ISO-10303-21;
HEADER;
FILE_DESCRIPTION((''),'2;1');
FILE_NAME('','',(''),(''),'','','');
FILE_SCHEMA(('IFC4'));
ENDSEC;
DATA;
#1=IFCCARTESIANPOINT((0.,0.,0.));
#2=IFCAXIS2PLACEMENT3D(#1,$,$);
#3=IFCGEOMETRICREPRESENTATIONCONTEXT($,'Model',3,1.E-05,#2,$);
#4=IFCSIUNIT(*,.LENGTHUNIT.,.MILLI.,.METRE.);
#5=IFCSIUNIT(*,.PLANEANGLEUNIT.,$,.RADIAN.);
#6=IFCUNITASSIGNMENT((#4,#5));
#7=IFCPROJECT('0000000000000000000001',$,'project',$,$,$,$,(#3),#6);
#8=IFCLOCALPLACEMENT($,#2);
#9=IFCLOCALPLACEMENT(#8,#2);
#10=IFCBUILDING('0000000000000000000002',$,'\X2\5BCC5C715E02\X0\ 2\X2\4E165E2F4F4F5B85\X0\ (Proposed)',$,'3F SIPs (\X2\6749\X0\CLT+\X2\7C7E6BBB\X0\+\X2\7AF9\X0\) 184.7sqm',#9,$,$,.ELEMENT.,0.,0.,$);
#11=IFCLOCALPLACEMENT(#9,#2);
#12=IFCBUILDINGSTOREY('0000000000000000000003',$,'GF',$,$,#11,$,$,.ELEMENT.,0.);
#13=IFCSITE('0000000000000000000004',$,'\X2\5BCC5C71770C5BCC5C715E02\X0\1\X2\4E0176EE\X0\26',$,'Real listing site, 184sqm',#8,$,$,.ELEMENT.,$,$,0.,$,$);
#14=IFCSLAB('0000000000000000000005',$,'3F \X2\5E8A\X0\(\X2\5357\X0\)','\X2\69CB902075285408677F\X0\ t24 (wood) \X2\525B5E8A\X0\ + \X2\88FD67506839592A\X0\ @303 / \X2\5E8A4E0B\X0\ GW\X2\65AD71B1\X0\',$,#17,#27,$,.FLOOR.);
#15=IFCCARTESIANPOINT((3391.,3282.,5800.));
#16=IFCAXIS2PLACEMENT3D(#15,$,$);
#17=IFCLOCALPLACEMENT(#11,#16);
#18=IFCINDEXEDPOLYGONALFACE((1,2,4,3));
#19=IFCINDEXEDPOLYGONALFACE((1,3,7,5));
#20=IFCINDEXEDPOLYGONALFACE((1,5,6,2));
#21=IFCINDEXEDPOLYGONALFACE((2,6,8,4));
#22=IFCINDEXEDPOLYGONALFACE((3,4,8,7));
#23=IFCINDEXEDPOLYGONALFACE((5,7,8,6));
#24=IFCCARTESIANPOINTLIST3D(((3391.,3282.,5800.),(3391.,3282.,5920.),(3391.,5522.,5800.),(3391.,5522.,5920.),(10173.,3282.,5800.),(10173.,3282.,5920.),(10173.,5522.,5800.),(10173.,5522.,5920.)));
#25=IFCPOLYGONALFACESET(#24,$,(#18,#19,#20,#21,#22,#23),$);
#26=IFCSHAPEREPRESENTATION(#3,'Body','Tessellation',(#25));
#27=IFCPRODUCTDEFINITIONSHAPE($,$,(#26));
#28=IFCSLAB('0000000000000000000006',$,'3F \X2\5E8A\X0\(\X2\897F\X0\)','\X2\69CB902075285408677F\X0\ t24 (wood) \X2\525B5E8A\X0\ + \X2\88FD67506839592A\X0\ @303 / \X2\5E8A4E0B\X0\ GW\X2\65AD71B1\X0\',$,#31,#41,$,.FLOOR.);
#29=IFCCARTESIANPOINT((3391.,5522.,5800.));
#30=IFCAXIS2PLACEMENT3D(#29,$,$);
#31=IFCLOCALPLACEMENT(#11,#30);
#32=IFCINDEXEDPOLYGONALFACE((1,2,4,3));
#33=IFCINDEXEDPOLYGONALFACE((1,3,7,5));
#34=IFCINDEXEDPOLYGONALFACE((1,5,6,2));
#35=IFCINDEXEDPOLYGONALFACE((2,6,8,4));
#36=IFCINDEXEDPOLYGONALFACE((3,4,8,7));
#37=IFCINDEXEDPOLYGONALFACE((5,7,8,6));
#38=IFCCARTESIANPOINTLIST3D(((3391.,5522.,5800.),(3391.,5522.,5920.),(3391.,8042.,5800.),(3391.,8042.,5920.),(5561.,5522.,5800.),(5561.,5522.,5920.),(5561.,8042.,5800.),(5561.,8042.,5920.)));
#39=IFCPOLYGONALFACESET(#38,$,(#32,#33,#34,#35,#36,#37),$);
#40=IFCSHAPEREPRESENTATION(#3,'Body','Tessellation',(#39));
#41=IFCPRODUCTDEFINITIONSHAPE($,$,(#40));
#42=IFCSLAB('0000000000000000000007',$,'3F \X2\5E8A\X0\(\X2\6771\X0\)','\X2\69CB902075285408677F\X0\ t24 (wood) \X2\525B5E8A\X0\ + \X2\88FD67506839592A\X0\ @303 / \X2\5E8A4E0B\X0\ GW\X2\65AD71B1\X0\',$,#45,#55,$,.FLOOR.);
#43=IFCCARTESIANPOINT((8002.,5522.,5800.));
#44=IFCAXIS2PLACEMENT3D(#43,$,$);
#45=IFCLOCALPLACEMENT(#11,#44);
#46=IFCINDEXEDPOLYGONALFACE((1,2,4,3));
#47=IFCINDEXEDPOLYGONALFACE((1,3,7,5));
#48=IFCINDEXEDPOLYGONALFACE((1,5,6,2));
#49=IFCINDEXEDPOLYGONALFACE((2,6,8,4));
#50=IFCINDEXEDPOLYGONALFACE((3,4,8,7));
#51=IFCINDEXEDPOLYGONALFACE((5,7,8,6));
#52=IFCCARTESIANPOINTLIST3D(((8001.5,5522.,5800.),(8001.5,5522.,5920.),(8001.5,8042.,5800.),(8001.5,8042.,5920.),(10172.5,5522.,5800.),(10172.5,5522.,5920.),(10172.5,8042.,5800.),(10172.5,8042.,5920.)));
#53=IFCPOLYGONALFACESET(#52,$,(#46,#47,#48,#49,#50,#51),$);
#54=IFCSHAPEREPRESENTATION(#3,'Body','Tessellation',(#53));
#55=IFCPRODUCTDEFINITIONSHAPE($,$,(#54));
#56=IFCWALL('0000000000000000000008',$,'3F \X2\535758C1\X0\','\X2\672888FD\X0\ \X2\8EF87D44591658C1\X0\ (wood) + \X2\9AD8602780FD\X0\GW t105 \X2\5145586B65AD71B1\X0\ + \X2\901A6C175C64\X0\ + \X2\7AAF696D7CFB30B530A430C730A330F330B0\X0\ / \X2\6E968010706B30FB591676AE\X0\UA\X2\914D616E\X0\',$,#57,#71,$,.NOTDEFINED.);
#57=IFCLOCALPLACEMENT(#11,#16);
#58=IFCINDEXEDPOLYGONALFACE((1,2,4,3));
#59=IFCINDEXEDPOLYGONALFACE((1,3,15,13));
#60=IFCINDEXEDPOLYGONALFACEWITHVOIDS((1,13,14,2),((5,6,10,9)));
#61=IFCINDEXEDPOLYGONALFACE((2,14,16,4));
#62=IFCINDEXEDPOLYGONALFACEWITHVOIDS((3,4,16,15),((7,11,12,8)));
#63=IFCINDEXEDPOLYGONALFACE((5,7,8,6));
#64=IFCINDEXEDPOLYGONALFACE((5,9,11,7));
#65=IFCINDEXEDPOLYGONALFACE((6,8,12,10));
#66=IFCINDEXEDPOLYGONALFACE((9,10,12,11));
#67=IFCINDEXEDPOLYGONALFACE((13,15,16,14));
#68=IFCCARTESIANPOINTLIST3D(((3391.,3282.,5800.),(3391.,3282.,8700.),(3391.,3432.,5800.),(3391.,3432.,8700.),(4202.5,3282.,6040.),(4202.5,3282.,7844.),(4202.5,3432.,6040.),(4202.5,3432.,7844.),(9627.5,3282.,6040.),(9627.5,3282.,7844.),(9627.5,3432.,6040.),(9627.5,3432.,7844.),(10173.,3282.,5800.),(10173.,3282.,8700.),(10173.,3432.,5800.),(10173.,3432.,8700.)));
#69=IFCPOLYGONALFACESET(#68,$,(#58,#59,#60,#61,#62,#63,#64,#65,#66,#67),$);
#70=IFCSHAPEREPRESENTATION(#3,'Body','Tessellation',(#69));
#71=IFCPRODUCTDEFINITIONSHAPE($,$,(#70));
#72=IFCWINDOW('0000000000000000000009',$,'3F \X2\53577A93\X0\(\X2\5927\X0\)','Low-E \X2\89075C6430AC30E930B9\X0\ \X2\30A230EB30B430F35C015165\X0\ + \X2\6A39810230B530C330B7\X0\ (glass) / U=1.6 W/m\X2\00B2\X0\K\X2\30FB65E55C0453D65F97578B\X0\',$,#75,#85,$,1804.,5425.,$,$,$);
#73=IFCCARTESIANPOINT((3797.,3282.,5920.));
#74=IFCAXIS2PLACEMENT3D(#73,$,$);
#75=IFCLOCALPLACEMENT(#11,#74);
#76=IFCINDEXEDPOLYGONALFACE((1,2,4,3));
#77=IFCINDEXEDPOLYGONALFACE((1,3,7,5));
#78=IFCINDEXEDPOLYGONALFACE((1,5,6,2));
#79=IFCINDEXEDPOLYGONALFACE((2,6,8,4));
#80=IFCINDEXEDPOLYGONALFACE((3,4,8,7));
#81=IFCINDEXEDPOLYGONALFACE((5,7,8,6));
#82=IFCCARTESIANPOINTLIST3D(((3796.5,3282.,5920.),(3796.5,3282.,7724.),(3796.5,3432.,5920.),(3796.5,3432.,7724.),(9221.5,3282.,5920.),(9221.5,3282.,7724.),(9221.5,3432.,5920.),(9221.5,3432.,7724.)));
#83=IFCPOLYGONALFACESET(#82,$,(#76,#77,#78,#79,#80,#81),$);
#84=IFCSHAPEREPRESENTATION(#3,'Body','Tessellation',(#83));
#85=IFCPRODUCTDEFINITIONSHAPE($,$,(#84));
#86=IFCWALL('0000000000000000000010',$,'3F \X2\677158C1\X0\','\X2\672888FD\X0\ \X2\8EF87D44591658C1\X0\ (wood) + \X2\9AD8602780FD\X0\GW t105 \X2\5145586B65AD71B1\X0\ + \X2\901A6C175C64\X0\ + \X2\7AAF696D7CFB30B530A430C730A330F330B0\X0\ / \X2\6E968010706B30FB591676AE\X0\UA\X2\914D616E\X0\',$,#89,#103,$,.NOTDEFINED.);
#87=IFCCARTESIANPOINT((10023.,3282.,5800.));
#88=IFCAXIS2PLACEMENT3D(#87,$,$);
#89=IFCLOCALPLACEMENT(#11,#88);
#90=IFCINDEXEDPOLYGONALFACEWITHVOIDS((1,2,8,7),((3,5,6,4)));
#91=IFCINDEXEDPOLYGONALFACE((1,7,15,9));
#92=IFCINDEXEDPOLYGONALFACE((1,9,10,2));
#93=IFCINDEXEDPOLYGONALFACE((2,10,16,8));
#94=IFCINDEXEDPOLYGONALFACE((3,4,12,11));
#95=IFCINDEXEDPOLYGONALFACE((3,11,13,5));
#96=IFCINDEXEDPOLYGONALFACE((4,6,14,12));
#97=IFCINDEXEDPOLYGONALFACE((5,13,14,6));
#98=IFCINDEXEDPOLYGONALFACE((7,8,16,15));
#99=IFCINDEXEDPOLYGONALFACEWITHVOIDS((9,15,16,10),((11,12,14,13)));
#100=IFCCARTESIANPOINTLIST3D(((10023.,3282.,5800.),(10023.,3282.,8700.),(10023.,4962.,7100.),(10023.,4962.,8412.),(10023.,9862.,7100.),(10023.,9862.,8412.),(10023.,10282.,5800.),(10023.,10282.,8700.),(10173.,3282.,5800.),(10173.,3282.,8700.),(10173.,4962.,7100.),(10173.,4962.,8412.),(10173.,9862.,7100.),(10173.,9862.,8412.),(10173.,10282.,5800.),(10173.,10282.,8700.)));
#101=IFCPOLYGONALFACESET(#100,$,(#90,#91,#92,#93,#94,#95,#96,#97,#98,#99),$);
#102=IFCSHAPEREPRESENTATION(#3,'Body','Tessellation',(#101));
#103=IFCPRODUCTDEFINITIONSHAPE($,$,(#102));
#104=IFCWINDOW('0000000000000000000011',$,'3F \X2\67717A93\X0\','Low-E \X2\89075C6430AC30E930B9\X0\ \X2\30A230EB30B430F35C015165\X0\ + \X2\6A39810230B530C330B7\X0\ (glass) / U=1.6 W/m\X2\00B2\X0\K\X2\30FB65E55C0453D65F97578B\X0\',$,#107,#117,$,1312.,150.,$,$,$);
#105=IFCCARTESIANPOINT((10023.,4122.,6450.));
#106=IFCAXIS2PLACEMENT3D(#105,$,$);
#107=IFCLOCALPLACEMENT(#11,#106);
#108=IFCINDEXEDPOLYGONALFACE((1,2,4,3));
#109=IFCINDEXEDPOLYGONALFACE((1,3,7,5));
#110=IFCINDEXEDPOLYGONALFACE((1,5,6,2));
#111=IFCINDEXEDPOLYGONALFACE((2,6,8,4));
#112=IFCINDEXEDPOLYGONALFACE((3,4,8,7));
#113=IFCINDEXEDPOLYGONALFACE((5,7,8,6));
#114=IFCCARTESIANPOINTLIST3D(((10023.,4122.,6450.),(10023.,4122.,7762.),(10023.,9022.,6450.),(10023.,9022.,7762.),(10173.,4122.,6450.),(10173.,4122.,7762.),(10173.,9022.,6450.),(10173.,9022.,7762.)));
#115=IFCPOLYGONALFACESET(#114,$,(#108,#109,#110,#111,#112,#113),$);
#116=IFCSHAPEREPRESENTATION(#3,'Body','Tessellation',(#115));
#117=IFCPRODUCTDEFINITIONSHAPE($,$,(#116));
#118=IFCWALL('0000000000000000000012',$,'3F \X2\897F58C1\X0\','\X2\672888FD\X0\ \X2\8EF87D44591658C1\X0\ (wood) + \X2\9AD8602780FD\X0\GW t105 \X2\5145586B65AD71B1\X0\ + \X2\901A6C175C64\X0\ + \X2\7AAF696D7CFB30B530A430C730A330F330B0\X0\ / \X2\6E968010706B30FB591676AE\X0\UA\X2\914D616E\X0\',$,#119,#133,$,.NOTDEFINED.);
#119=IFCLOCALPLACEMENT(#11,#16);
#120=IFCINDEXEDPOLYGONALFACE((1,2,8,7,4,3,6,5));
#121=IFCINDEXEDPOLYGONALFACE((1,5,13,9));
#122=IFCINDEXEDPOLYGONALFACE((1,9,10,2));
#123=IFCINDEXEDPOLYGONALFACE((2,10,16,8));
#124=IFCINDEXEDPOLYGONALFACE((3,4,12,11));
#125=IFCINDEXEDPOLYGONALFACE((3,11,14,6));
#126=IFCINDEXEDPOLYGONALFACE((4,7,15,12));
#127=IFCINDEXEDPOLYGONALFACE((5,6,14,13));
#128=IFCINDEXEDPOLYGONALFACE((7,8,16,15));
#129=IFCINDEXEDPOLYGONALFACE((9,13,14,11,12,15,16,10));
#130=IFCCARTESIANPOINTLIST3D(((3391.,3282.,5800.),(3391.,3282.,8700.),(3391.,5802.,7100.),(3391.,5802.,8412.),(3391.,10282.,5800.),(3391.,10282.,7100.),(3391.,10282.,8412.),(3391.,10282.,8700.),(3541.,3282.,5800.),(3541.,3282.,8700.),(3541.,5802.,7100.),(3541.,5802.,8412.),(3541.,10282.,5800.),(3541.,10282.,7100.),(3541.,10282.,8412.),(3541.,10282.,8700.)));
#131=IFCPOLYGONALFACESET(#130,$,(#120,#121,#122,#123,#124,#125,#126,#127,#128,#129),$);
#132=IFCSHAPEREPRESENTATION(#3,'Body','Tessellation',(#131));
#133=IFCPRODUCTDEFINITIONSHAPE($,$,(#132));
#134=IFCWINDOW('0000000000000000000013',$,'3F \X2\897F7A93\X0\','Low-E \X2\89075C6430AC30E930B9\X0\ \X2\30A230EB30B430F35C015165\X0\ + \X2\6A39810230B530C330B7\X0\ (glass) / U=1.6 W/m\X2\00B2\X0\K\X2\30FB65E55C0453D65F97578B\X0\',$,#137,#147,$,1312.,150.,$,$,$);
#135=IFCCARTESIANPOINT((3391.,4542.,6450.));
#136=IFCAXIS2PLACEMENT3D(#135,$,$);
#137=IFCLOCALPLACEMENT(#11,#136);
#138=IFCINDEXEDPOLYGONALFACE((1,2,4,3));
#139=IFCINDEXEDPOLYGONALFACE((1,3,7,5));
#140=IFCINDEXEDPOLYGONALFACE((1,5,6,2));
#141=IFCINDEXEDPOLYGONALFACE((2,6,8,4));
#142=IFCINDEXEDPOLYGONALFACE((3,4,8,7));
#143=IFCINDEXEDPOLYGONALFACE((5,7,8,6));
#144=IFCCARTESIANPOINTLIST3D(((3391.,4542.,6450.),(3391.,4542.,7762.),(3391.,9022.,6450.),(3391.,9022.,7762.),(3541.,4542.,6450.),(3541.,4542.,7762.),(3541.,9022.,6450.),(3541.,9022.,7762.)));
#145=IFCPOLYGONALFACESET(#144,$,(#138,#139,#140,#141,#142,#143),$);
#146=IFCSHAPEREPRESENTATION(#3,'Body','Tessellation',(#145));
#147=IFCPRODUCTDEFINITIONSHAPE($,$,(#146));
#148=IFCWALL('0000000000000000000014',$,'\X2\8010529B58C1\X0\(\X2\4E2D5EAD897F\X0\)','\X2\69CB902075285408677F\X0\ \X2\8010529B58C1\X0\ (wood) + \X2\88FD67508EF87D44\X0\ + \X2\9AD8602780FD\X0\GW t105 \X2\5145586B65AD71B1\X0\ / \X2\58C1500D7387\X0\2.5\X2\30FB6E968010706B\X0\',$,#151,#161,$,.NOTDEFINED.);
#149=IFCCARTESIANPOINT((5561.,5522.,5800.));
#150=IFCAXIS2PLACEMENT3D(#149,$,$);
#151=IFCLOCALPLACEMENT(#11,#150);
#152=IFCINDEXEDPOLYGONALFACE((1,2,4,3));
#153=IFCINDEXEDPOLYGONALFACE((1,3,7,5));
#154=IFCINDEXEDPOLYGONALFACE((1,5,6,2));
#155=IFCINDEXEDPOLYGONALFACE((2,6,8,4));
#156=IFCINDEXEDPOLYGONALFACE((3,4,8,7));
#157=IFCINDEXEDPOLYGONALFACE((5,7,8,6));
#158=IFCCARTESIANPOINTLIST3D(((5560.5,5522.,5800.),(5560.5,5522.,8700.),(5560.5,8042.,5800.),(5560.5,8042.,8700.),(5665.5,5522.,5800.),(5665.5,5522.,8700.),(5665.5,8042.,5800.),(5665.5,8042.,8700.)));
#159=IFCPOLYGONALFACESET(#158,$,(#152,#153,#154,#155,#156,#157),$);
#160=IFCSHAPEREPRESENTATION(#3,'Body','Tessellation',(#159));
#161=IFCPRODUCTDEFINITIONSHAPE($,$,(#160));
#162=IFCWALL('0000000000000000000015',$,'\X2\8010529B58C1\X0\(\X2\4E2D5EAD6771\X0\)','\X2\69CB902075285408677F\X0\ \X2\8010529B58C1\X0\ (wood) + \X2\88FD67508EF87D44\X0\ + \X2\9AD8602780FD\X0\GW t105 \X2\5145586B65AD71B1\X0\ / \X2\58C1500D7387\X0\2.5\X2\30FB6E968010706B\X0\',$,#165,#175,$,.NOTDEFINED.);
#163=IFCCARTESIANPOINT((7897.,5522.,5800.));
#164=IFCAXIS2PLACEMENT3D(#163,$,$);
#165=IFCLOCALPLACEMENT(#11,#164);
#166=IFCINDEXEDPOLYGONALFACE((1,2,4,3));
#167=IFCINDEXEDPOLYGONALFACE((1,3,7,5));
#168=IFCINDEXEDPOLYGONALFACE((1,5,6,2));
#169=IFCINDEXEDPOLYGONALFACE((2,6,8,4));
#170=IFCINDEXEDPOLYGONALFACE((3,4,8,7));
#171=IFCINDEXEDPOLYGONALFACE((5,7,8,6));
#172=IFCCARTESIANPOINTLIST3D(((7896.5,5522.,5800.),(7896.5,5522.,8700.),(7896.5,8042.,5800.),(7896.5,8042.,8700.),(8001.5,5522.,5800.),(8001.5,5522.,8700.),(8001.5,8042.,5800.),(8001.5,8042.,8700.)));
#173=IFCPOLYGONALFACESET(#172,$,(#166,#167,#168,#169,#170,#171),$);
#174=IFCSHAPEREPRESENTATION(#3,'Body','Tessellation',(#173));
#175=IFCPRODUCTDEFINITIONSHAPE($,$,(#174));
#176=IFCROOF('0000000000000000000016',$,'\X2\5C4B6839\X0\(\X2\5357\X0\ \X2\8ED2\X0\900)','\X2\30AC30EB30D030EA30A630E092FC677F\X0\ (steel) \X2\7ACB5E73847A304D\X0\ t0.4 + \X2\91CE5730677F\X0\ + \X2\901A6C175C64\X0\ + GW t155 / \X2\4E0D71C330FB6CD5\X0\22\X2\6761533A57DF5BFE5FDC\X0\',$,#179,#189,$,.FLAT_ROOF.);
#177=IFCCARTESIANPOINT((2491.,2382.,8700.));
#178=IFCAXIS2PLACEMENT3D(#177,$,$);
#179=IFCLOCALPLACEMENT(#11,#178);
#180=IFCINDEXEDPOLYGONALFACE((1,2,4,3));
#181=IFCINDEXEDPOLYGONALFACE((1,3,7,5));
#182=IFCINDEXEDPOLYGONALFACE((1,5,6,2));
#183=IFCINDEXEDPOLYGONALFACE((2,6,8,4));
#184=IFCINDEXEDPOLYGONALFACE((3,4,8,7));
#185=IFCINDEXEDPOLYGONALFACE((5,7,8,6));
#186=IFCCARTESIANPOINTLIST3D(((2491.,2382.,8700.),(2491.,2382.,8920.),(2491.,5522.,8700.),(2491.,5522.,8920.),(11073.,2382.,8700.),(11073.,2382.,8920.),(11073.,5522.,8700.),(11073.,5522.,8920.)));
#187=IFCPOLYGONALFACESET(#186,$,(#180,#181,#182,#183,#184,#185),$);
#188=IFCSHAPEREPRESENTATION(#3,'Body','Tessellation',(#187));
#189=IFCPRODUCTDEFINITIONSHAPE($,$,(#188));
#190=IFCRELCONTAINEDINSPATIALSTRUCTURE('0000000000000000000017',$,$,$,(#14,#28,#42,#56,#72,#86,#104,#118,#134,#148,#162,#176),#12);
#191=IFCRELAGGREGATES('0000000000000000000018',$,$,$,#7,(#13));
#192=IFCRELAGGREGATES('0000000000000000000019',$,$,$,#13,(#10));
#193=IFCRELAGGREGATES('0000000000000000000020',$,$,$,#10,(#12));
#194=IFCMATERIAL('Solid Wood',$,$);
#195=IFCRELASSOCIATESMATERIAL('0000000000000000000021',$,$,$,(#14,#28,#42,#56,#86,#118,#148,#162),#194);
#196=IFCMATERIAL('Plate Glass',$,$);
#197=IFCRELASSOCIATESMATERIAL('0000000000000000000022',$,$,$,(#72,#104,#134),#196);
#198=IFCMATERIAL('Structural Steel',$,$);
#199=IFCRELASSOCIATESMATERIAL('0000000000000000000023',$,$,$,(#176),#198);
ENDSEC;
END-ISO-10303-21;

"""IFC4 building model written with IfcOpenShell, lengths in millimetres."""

from ifc_helpers import new_model, si_unit, frame, frame_2d, origin, place, context, project, spatial, rectangle, extrude, material, element, fill, save


model = new_model("IFC4")

# Units and contexts
model_context = context("Model", 3, precision=1e-05, world=origin())
ifc_project = project(units=[si_unit("LENGTHUNIT", "METRE", prefix="MILLI"), si_unit("PLANEANGLEUNIT", "RADIAN")], contexts=[model_context])

# Site, building, storey
site_placement = place(None, origin())
site = spatial("IfcSite", under=ifc_project, at=site_placement, Name="富山県富山市1丁目26", ObjectType="Real listing site, 184sqm", CompositionType="ELEMENT", RefElevation=0.0)
building_placement = place(site_placement, origin())
building = spatial("IfcBuilding", under=site, at=building_placement, Name="富山市 2世帯住宅 (Proposed)", ObjectType="3F SIPs (杉CLT+籾殻+竹) 184.7sqm", CompositionType="ELEMENT", ElevationOfRefHeight=0.0, ElevationOfTerrain=0.0)
storey_placement = place(building_placement, origin())
storey = spatial("IfcBuildingStorey", under=building, at=storey_placement, Name="GF", CompositionType="ELEMENT", Elevation=0.0)

# Slabs
ifc_material_1 = material(Name="Solid Wood")
slab_1_placement = place(storey_placement, frame((3391.0, 3282.0, 5800.0)))
element("IfcSlab", 1, at=slab_1_placement, inside=storey, material=ifc_material_1, Name="3F 床(南)", Description="構造用合板 t24 (wood) 剛床 + 製材根太 @303 / 床下 GW断熱", PredefinedType="FLOOR", context=model_context, shape_type="SweptSolid", body=[
    extrude(rectangle(XDim=6782.0, YDim=2240.0, at=frame_2d((3391.0, 1120.0))), frame((3391.0, 3282.0, 5800.0)), (0.0, 0.0, 1.0), 120.0),
])
slab_2_placement = place(storey_placement, frame((3391.0, 5522.0, 5800.0)))
element("IfcSlab", 2, at=slab_2_placement, inside=storey, material=ifc_material_1, Name="3F 床(西)", Description="構造用合板 t24 (wood) 剛床 + 製材根太 @303 / 床下 GW断熱", PredefinedType="FLOOR", context=model_context, shape_type="SweptSolid", body=[
    extrude(rectangle(XDim=2170.0, YDim=2520.0, at=frame_2d((1085.0, 1260.0))), frame((3391.0, 5522.0, 5800.0)), (0.0, 0.0, 1.0), 120.0),
])
slab_3_placement = place(storey_placement, frame((8002.0, 5522.0, 5800.0)))
element("IfcSlab", 3, at=slab_3_placement, inside=storey, material=ifc_material_1, Name="3F 床(東)", Description="構造用合板 t24 (wood) 剛床 + 製材根太 @303 / 床下 GW断熱", PredefinedType="FLOOR", context=model_context, shape_type="SweptSolid", body=[
    extrude(rectangle(XDim=2171.0, YDim=2520.0, at=frame_2d((1085.0, 1260.0))), frame((8002.0, 5522.0, 5800.0)), (0.0, 0.0, 1.0), 120.0),
])

# Walls, openings, windows
wall_1_placement = place(storey_placement, frame((3391.0, 3282.0, 5800.0)))
wall_1 = element("IfcWall", 4, at=wall_1_placement, inside=storey, material=ifc_material_1, Name="3F 南壁", Description="木製 軸組外壁 (wood) + 高性能GW t105 充填断熱 + 通気層 + 窯業系サイディング / 準耐火・外皮UA配慮", PredefinedType="NOTDEFINED", context=model_context, shape_type="SweptSolid", body=[
    extrude(rectangle(XDim=6782.0, YDim=150.0, at=frame_2d((3391.0, 75.0))), frame((3391.0, 3282.0, 5800.0)), (0.0, 0.0, 1.0), 2900.0),
])
opening_1_placement = place(storey_placement, frame((3797.0, 3282.0, 5920.0)))
opening_1 = element("IfcOpeningElement", 5, at=opening_1_placement, cuts=wall_1, PredefinedType="NOTDEFINED", context=model_context, shape_type="SweptSolid", body=[
    extrude(rectangle(XDim=5425.0, YDim=150.0, at=frame_2d((2712.0, 75.0))), frame((3797.0, 3282.0, 5920.0)), (0.0, 0.0, 1.0), 1804.0),
])
ifc_material_2 = material(Name="Plate Glass")
window_1_placement = place(storey_placement, frame((3797.0, 3282.0, 5920.0)))
window_1 = element("IfcWindow", 6, at=window_1_placement, inside=storey, material=ifc_material_2, Name="3F 南窓(大)", Description="Low-E 複層ガラス アルゴン封入 + 樹脂サッシ (glass) / U=1.6 W/m²K・日射取得型", OverallHeight=1804.0, OverallWidth=5425.0, context=model_context, shape_type="SweptSolid", body=[
    extrude(rectangle(XDim=5425.0, YDim=150.0, at=frame_2d((2712.0, 75.0))), frame((3797.0, 3282.0, 5920.0)), (0.0, 0.0, 1.0), 1804.0),
])
fill(opening_1, window_1)
wall_2_placement = place(storey_placement, frame((10023.0, 3282.0, 5800.0)))
wall_2 = element("IfcWall", 7, at=wall_2_placement, inside=storey, material=ifc_material_1, Name="3F 東壁", Description="木製 軸組外壁 (wood) + 高性能GW t105 充填断熱 + 通気層 + 窯業系サイディング / 準耐火・外皮UA配慮", PredefinedType="NOTDEFINED", context=model_context, shape_type="SweptSolid", body=[
    extrude(rectangle(XDim=150.0, YDim=7000.0, at=frame_2d((75.0, 3500.0))), frame((10023.0, 3282.0, 5800.0)), (0.0, 0.0, 1.0), 2900.0),
])
opening_2_placement = place(storey_placement, frame((10023.0, 4122.0, 6450.0)))
opening_2 = element("IfcOpeningElement", 8, at=opening_2_placement, cuts=wall_2, PredefinedType="NOTDEFINED", context=model_context, shape_type="SweptSolid", body=[
    extrude(rectangle(XDim=150.0, YDim=4900.0, at=frame_2d((75.0, 2450.0))), frame((10023.0, 4122.0, 6450.0)), (0.0, 0.0, 1.0), 1312.0),
])
window_2_placement = place(storey_placement, frame((10023.0, 4122.0, 6450.0)))
window_2 = element("IfcWindow", 9, at=window_2_placement, inside=storey, material=ifc_material_2, Name="3F 東窓", Description="Low-E 複層ガラス アルゴン封入 + 樹脂サッシ (glass) / U=1.6 W/m²K・日射取得型", OverallHeight=1312.0, OverallWidth=150.0, context=model_context, shape_type="SweptSolid", body=[
    extrude(rectangle(XDim=150.0, YDim=4900.0, at=frame_2d((75.0, 2450.0))), frame((10023.0, 4122.0, 6450.0)), (0.0, 0.0, 1.0), 1312.0),
])
fill(opening_2, window_2)
wall_3_placement = place(storey_placement, frame((3391.0, 3282.0, 5800.0)))
wall_3 = element("IfcWall", 10, at=wall_3_placement, inside=storey, material=ifc_material_1, Name="3F 西壁", Description="木製 軸組外壁 (wood) + 高性能GW t105 充填断熱 + 通気層 + 窯業系サイディング / 準耐火・外皮UA配慮", PredefinedType="NOTDEFINED", context=model_context, shape_type="SweptSolid", body=[
    extrude(rectangle(XDim=150.0, YDim=7000.0, at=frame_2d((75.0, 3500.0))), frame((3391.0, 3282.0, 5800.0)), (0.0, 0.0, 1.0), 2900.0),
])
opening_3_placement = place(storey_placement, frame((3391.0, 4542.0, 6450.0)))
opening_3 = element("IfcOpeningElement", 11, at=opening_3_placement, cuts=wall_3, PredefinedType="NOTDEFINED", context=model_context, shape_type="SweptSolid", body=[
    extrude(rectangle(XDim=150.0, YDim=4480.0, at=frame_2d((75.0, 2240.0))), frame((3391.0, 4542.0, 6450.0)), (0.0, 0.0, 1.0), 1312.0),
])
window_3_placement = place(storey_placement, frame((3391.0, 4542.0, 6450.0)))
window_3 = element("IfcWindow", 12, at=window_3_placement, inside=storey, material=ifc_material_2, Name="3F 西窓", Description="Low-E 複層ガラス アルゴン封入 + 樹脂サッシ (glass) / U=1.6 W/m²K・日射取得型", OverallHeight=1312.0, OverallWidth=150.0, context=model_context, shape_type="SweptSolid", body=[
    extrude(rectangle(XDim=150.0, YDim=4480.0, at=frame_2d((75.0, 2240.0))), frame((3391.0, 4542.0, 6450.0)), (0.0, 0.0, 1.0), 1312.0),
])
fill(opening_3, window_3)

# Walls
wall_4_placement = place(storey_placement, frame((5561.0, 5522.0, 5800.0)))
element("IfcWall", 13, at=wall_4_placement, inside=storey, material=ifc_material_1, Name="耐力壁(中庭西)", Description="構造用合板 耐力壁 (wood) + 製材軸組 + 高性能GW t105 充填断熱 / 壁倍率2.5・準耐火", PredefinedType="NOTDEFINED", context=model_context, shape_type="SweptSolid", body=[
    extrude(rectangle(XDim=105.0, YDim=2520.0, at=frame_2d((52.0, 1260.0))), frame((5561.0, 5522.0, 5800.0)), (0.0, 0.0, 1.0), 2900.0),
])
wall_5_placement = place(storey_placement, frame((7897.0, 5522.0, 5800.0)))
element("IfcWall", 14, at=wall_5_placement, inside=storey, material=ifc_material_1, Name="耐力壁(中庭東)", Description="構造用合板 耐力壁 (wood) + 製材軸組 + 高性能GW t105 充填断熱 / 壁倍率2.5・準耐火", PredefinedType="NOTDEFINED", context=model_context, shape_type="SweptSolid", body=[
    extrude(rectangle(XDim=105.0, YDim=2520.0, at=frame_2d((52.0, 1260.0))), frame((7897.0, 5522.0, 5800.0)), (0.0, 0.0, 1.0), 2900.0),
])

# Roof
ifc_material_3 = material(Name="Structural Steel")
roof_1_placement = place(storey_placement, frame((2491.0, 2382.0, 8700.0)))
element("IfcRoof", 15, at=roof_1_placement, inside=storey, material=ifc_material_3, Name="屋根(南 軒900)", Description="ガルバリウム鋼板 (steel) 立平葺き t0.4 + 野地板 + 通気層 + GW t155 / 不燃・法22条区域対応", PredefinedType="FLAT_ROOF", context=model_context, shape_type="SweptSolid", body=[
    extrude(rectangle(XDim=8582.0, YDim=3140.0, at=frame_2d((4291.0, 1570.0))), frame((2491.0, 2382.0, 8700.0)), (0.0, 0.0, 1.0), 220.0),
])

save(model, "model.ifc")
